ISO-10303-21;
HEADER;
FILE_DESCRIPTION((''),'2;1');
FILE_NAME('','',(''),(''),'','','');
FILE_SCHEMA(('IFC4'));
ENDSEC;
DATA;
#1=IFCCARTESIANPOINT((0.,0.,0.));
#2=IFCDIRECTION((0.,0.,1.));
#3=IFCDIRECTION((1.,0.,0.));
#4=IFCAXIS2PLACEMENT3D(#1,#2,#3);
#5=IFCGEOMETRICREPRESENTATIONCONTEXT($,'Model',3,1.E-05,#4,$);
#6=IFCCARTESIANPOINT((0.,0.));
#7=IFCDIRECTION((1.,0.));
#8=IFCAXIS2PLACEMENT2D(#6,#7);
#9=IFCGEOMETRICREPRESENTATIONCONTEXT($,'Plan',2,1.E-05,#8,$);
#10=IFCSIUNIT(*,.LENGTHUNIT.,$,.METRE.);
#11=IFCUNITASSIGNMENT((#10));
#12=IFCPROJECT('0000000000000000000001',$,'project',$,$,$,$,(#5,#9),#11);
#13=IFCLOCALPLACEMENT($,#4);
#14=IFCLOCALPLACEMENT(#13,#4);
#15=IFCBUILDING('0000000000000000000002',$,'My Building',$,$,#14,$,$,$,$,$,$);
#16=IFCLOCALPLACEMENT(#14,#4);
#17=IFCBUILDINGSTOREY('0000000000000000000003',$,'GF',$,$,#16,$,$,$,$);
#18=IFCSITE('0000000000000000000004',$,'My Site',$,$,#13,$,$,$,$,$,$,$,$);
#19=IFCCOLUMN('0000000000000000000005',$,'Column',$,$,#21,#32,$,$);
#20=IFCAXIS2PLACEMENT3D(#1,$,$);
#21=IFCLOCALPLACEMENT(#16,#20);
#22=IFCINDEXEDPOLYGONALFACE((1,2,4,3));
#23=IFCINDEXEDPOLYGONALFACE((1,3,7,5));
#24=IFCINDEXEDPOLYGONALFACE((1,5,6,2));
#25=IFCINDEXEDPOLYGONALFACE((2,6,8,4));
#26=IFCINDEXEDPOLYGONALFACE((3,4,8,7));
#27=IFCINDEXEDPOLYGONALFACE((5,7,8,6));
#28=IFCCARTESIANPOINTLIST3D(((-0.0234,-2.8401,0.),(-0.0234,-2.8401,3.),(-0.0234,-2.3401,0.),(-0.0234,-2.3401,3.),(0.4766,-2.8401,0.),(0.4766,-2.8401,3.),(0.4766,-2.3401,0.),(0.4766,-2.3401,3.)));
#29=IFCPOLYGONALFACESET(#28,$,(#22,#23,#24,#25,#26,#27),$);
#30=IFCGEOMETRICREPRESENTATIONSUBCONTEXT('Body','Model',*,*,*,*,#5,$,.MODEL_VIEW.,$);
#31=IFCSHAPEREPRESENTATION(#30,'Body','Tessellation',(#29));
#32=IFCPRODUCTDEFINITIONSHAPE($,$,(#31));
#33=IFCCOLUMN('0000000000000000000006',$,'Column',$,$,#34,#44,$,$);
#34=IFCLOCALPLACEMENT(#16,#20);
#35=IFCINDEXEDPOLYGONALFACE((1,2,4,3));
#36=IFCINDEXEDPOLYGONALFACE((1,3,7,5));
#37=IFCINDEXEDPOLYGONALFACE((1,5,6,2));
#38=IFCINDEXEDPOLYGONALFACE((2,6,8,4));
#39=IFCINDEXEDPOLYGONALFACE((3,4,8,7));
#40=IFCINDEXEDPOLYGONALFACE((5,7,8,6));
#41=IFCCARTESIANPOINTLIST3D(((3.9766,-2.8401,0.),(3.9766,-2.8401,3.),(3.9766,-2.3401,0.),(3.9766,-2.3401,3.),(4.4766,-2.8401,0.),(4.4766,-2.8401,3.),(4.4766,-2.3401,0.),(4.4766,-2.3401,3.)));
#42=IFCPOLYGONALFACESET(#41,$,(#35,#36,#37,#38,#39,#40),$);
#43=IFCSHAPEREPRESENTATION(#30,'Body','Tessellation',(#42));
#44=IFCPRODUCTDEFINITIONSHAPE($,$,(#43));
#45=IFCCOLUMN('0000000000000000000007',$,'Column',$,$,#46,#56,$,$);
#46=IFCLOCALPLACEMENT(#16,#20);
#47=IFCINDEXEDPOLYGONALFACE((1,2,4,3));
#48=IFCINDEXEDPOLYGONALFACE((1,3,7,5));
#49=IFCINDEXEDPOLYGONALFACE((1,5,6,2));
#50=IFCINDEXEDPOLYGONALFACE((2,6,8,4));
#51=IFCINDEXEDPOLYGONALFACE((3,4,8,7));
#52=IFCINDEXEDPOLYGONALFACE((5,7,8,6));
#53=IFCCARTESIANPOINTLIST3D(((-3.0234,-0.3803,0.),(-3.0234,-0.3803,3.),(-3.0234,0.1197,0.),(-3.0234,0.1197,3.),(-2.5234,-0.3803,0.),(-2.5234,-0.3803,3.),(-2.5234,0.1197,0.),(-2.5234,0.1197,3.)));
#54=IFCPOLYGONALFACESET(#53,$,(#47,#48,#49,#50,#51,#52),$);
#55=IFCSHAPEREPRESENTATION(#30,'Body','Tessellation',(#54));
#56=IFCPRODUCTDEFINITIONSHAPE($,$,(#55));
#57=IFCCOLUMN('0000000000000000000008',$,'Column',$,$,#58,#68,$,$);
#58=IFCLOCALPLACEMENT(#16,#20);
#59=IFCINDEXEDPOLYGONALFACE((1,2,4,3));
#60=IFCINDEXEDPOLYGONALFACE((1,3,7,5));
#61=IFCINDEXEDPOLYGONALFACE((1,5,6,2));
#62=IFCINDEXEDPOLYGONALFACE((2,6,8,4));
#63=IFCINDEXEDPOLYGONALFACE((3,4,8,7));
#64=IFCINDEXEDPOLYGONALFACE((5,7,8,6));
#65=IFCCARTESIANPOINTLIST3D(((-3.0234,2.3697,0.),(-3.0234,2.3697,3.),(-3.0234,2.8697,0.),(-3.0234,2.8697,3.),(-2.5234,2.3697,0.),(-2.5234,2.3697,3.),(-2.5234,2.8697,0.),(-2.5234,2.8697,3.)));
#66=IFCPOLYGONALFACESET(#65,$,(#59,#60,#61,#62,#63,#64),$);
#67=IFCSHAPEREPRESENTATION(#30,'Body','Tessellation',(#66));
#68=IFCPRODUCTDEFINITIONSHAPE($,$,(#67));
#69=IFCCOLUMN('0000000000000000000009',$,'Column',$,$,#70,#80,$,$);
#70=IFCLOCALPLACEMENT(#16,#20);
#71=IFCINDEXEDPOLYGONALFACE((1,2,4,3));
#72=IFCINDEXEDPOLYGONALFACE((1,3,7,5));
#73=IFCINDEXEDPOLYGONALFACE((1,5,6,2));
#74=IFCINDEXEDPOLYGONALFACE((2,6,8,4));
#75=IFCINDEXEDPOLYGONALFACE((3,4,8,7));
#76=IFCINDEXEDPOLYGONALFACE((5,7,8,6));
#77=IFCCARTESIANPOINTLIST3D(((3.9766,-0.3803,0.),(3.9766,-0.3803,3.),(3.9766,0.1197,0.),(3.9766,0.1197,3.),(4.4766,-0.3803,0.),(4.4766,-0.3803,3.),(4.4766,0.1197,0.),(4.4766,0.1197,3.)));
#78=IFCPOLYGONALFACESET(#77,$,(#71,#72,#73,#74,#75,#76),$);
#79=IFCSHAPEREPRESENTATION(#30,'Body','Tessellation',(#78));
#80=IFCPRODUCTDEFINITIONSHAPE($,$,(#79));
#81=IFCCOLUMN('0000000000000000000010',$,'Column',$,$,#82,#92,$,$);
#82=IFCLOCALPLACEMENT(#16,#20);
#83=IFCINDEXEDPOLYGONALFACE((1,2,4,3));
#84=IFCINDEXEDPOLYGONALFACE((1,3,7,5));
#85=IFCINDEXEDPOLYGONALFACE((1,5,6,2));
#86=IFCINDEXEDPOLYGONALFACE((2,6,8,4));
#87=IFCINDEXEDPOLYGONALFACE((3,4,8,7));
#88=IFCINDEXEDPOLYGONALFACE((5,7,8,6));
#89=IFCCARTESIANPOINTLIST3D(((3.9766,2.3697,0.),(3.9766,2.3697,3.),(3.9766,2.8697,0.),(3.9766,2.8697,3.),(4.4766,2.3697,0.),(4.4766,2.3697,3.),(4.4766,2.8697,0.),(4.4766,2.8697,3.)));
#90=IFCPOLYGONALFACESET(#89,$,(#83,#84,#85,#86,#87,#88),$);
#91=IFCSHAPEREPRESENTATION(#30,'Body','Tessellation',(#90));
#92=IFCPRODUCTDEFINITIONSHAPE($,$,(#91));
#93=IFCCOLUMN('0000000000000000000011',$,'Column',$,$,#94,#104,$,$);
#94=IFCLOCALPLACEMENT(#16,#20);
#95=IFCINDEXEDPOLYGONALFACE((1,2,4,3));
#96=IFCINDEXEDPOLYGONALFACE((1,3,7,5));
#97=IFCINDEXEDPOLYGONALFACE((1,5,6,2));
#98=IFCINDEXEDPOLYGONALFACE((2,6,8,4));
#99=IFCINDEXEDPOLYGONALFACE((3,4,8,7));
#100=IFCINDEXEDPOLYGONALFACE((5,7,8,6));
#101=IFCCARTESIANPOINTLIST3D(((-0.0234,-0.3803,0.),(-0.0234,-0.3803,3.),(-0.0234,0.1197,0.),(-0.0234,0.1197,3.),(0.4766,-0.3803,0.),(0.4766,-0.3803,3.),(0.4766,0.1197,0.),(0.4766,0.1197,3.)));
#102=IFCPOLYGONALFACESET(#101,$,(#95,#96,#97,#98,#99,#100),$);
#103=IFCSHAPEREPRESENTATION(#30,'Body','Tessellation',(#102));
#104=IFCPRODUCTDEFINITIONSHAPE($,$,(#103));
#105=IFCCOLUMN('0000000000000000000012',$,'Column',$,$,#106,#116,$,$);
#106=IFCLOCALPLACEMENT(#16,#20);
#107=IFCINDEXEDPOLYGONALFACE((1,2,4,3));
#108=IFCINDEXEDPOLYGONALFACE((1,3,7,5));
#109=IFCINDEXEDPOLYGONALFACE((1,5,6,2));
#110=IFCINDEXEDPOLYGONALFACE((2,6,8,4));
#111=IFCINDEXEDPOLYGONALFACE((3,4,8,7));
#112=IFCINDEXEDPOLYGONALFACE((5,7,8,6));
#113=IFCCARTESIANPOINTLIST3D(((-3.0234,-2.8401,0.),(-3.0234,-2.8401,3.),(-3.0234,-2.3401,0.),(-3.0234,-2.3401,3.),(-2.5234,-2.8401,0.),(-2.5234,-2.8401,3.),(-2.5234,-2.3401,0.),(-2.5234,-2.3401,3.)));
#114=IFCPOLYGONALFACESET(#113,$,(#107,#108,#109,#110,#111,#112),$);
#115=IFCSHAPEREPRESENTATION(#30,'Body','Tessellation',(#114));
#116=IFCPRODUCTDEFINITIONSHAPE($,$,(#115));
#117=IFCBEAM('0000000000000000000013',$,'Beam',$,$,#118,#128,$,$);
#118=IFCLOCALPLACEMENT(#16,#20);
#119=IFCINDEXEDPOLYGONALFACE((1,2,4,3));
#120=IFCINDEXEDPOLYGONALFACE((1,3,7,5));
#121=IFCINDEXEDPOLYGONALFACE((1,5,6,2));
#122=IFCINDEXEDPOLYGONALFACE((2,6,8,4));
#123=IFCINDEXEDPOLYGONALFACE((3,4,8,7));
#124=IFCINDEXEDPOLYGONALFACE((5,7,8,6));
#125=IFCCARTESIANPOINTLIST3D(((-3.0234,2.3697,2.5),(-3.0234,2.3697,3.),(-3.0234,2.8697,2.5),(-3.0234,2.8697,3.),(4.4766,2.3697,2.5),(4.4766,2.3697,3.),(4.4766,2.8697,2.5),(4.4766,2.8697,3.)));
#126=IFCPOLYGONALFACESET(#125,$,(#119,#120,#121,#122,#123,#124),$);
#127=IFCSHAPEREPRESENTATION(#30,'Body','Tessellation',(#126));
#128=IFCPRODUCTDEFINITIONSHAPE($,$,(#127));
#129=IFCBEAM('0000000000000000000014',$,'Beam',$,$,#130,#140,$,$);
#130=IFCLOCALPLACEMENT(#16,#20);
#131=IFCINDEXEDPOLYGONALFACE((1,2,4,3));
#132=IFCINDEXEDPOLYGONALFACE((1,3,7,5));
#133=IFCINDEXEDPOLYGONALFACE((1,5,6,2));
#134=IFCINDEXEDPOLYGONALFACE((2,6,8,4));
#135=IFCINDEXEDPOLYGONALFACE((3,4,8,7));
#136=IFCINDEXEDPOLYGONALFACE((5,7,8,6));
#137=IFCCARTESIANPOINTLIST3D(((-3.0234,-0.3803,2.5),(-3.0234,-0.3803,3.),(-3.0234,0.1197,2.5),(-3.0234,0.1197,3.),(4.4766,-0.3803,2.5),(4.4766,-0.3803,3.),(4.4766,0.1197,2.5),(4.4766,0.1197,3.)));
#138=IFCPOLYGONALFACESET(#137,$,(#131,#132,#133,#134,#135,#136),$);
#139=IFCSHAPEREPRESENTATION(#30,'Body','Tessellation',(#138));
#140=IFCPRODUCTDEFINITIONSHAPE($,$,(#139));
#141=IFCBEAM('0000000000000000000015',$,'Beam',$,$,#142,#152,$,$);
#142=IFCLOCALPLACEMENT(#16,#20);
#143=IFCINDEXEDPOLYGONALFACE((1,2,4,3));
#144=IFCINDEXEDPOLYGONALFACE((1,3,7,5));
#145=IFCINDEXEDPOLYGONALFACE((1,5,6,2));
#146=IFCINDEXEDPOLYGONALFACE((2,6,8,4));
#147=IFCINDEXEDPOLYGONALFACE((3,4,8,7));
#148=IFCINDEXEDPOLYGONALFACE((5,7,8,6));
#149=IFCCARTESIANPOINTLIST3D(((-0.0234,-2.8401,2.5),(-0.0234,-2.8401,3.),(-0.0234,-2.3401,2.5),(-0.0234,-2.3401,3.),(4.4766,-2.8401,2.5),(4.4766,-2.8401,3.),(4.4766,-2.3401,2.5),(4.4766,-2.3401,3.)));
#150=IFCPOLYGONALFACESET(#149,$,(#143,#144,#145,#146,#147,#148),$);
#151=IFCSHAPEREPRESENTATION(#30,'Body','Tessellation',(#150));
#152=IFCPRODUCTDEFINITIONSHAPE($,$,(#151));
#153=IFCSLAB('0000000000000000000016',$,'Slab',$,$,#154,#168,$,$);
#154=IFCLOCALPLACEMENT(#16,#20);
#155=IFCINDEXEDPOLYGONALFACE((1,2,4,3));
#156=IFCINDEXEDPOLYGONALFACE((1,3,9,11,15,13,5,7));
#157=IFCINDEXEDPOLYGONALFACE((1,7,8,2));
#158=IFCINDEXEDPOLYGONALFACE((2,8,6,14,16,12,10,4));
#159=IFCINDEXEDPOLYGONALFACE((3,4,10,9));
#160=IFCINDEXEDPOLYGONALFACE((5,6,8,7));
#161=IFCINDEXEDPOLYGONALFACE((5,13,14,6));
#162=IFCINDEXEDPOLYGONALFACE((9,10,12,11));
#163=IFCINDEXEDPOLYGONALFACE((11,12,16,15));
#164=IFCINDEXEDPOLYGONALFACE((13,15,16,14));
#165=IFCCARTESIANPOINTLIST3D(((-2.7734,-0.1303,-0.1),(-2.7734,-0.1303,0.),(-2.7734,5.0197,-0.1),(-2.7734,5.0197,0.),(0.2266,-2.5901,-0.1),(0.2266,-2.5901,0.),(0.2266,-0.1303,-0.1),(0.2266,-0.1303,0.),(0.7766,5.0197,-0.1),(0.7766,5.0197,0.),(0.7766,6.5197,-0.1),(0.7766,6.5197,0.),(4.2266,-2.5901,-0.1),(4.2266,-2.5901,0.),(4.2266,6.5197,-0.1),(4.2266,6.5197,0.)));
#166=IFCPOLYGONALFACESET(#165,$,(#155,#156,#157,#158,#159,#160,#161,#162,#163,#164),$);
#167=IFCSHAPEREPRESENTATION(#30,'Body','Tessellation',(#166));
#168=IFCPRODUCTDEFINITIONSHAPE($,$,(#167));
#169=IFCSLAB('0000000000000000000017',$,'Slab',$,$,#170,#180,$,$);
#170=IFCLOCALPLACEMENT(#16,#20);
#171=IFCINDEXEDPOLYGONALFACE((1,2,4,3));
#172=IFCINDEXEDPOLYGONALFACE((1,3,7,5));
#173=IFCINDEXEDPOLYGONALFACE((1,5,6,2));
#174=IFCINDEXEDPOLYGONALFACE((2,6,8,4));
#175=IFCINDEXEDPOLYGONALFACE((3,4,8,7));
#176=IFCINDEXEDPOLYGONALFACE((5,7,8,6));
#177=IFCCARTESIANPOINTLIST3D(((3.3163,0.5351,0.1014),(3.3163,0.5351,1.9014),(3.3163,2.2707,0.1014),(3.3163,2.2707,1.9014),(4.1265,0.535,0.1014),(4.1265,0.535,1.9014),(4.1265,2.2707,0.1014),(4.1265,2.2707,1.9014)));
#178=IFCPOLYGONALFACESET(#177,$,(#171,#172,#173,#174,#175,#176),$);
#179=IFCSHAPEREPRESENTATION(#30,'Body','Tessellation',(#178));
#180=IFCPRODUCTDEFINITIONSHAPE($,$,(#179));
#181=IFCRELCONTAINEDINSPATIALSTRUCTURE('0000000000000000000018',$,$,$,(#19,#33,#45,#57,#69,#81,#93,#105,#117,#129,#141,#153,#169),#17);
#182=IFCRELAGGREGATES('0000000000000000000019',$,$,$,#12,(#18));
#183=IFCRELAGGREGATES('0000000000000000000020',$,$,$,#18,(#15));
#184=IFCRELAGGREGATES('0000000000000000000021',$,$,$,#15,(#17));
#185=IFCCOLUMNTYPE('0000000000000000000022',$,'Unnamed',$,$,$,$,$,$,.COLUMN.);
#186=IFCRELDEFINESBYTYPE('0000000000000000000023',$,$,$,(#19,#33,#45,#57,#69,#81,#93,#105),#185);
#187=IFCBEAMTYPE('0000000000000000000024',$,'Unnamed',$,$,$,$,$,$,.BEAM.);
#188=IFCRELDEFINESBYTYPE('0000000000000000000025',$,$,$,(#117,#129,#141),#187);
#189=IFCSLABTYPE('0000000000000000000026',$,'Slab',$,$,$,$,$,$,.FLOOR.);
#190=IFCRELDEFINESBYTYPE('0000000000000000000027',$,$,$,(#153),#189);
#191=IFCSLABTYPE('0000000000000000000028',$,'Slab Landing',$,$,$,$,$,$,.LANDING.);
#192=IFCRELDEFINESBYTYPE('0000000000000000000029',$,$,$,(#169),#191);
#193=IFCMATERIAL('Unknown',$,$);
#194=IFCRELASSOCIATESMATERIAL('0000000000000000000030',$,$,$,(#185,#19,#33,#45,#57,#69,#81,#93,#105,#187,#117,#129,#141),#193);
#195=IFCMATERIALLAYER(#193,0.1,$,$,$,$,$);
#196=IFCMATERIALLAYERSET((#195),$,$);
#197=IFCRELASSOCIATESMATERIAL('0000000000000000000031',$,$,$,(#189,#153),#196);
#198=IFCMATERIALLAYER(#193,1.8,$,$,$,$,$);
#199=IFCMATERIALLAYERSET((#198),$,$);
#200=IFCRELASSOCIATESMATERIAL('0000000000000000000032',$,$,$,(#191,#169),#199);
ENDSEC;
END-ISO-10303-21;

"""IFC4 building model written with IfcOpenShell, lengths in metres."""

from ifc_helpers import new_model, si_unit, frame, origin_with_axes, origin_2d_with_axis, place, context, subcontext, project, spatial, indexed_curve, rectangle, outline, extrude, material, layer, layer_set, layer_usage, material_profile, profile_set, profile_usage, type_object, element, save


model = new_model("IFC4")

# Units and contexts
model_context = context("Model", 3, precision=1e-05, world=origin_with_axes())
plan_context = context("Plan", 2, precision=1e-05, world=origin_2d_with_axis())
body_context_1 = subcontext(model_context, "Body", "Model", "MODEL_VIEW")
ifc_project = project(units=[si_unit("LENGTHUNIT", "METRE")], contexts=[model_context, plan_context])

# Site, building, storey
site_placement = place(None, origin_with_axes())
site = spatial("IfcSite", under=ifc_project, at=site_placement, Name="My Site")
building_placement = place(site_placement, origin_with_axes())
building = spatial("IfcBuilding", under=site, at=building_placement, Name="My Building")
storey_placement = place(building_placement, origin_with_axes())
storey = spatial("IfcBuildingStorey", under=building, at=storey_placement, Name="GF")

# Columns
ifc_material = material(Name="Unknown")
ifc_material_profile_1 = material_profile(ifc_material, rectangle(XDim=0.5, YDim=0.5))
ifc_profile_set_1 = profile_set([ifc_material_profile_1])
ifc_profile_usage_1 = profile_usage(ifc_profile_set_1, cardinal=5)
column_type = type_object("IfcColumnType", Name="Unnamed", PredefinedType="COLUMN", material=ifc_profile_set_1)
column_1_placement = place(storey_placement, frame((0.2266, -2.5901, 0.0), z_axis=(0.0, 0.0, 1.0), x_axis=(1.0, 0.0, 0.0)))
element("IfcColumn", 1, at=column_1_placement, inside=storey, type_object=column_type, material=ifc_profile_usage_1, Name="Column", context=body_context_1, shape_type="SweptSolid", body=[
    extrude(rectangle(XDim=0.5, YDim=0.5), origin_with_axes(), (0.0, 0.0, 1.0), 3.0),
])
ifc_profile_usage_2 = profile_usage(ifc_profile_set_1, cardinal=5)
column_2_placement = place(storey_placement, frame((4.2266, -2.5901, 0.0), z_axis=(0.0, 0.0, 1.0), x_axis=(1.0, 0.0, 0.0)))
element("IfcColumn", 2, at=column_2_placement, inside=storey, type_object=column_type, material=ifc_profile_usage_2, Name="Column", context=body_context_1, shape_type="SweptSolid", body=[
    extrude(rectangle(XDim=0.5, YDim=0.5), origin_with_axes(), (0.0, 0.0, 1.0), 3.0),
])
ifc_profile_usage_3 = profile_usage(ifc_profile_set_1, cardinal=5)
column_3_placement = place(storey_placement, frame((-2.7734, -0.1303, 0.0), z_axis=(0.0, 0.0, 1.0), x_axis=(1.0, 0.0, 0.0)))
element("IfcColumn", 3, at=column_3_placement, inside=storey, type_object=column_type, material=ifc_profile_usage_3, Name="Column", context=body_context_1, shape_type="SweptSolid", body=[
    extrude(rectangle(XDim=0.5, YDim=0.5), origin_with_axes(), (0.0, 0.0, 1.0), 3.0),
])
ifc_profile_usage_4 = profile_usage(ifc_profile_set_1, cardinal=5)
column_4_placement = place(storey_placement, frame((-2.7734, 2.6197, 0.0), z_axis=(0.0, 0.0, 1.0), x_axis=(1.0, 0.0, 0.0)))
element("IfcColumn", 4, at=column_4_placement, inside=storey, type_object=column_type, material=ifc_profile_usage_4, Name="Column", context=body_context_1, shape_type="SweptSolid", body=[
    extrude(rectangle(XDim=0.5, YDim=0.5), origin_with_axes(), (0.0, 0.0, 1.0), 3.0),
])
ifc_profile_usage_5 = profile_usage(ifc_profile_set_1, cardinal=5)
column_5_placement = place(storey_placement, frame((4.2266, -0.1303, 0.0), z_axis=(0.0, 0.0, 1.0), x_axis=(1.0, 0.0, 0.0)))
element("IfcColumn", 5, at=column_5_placement, inside=storey, type_object=column_type, material=ifc_profile_usage_5, Name="Column", context=body_context_1, shape_type="SweptSolid", body=[
    extrude(rectangle(XDim=0.5, YDim=0.5), origin_with_axes(), (0.0, 0.0, 1.0), 3.0),
])
ifc_profile_usage_6 = profile_usage(ifc_profile_set_1, cardinal=5)
column_6_placement = place(storey_placement, frame((4.2266, 2.6197, 0.0), z_axis=(0.0, 0.0, 1.0), x_axis=(1.0, 0.0, 0.0)))
element("IfcColumn", 6, at=column_6_placement, inside=storey, type_object=column_type, material=ifc_profile_usage_6, Name="Column", context=body_context_1, shape_type="SweptSolid", body=[
    extrude(rectangle(XDim=0.5, YDim=0.5), origin_with_axes(), (0.0, 0.0, 1.0), 3.0),
])
ifc_profile_usage_7 = profile_usage(ifc_profile_set_1, cardinal=5)
column_7_placement = place(storey_placement, frame((0.2266, -0.1303, 0.0), z_axis=(0.0, 0.0, 1.0), x_axis=(1.0, 0.0, 0.0)))
element("IfcColumn", 7, at=column_7_placement, inside=storey, type_object=column_type, material=ifc_profile_usage_7, Name="Column", context=body_context_1, shape_type="SweptSolid", body=[
    extrude(rectangle(XDim=0.5, YDim=0.5), origin_with_axes(), (0.0, 0.0, 1.0), 3.0),
])
ifc_profile_usage_8 = profile_usage(ifc_profile_set_1, cardinal=5)
column_8_placement = place(storey_placement, frame((-2.7734, -2.5901, 0.0), z_axis=(0.0, 0.0, 1.0), x_axis=(1.0, 0.0, 0.0)))
element("IfcColumn", 8, at=column_8_placement, inside=storey, type_object=column_type, material=ifc_profile_usage_8, Name="Column", context=body_context_1, shape_type="SweptSolid", body=[
    extrude(rectangle(XDim=0.5, YDim=0.5), origin_with_axes(), (0.0, 0.0, 1.0), 3.0),
])

# Beams
ifc_material_profile_2 = material_profile(ifc_material, rectangle(XDim=0.5, YDim=0.5))
ifc_profile_set_2 = profile_set([ifc_material_profile_2])
ifc_profile_usage_9 = profile_usage(ifc_profile_set_2, cardinal=7)
beam_type = type_object("IfcBeamType", Name="Unnamed", PredefinedType="BEAM", material=ifc_profile_set_2)
beam_1_placement = place(storey_placement, frame((4.4766, 2.3697, 3.0), z_axis=(-1.0, 0.0, 0.0), x_axis=(0.0, -1.0, 0.0)))
element("IfcBeam", 9, at=beam_1_placement, inside=storey, type_object=beam_type, material=ifc_profile_usage_9, Name="Beam", context=body_context_1, shape_type="SweptSolid", body=[
    extrude(rectangle(XDim=0.5, YDim=0.5), frame((-0.25, -0.25, 0.0), z_axis=(0.0, 0.0, 1.0), x_axis=(1.0, 0.0, 0.0)), (0.0, 0.0, 1.0), 7.5),
])
ifc_profile_usage_10 = profile_usage(ifc_profile_set_2, cardinal=7)
beam_2_placement = place(storey_placement, frame((4.4766, -0.3803, 3.0), z_axis=(-1.0, 0.0, 0.0), x_axis=(0.0, -1.0, 0.0)))
element("IfcBeam", 10, at=beam_2_placement, inside=storey, type_object=beam_type, material=ifc_profile_usage_10, Name="Beam", context=body_context_1, shape_type="SweptSolid", body=[
    extrude(rectangle(XDim=0.5, YDim=0.5), frame((-0.25, -0.25, 0.0), z_axis=(0.0, 0.0, 1.0), x_axis=(1.0, 0.0, 0.0)), (0.0, 0.0, 1.0), 7.5),
])
ifc_profile_usage_11 = profile_usage(ifc_profile_set_2, cardinal=7)
beam_3_placement = place(storey_placement, frame((4.4766, -2.8401, 3.0), z_axis=(-1.0, -0.000001, 0.000001), x_axis=(0.000001, -1.0, 0.0)))
element("IfcBeam", 11, at=beam_3_placement, inside=storey, type_object=beam_type, material=ifc_profile_usage_11, Name="Beam", context=body_context_1, shape_type="SweptSolid", body=[
    extrude(rectangle(XDim=0.5, YDim=0.5), frame((-0.25, -0.25, 0.0), z_axis=(0.0, 0.0, 1.0), x_axis=(1.0, 0.0, 0.0)), (0.0, 0.0, 1.0), 4.5),
])

# Slabs
ifc_layer_1 = layer(ifc_material, 0.1)
ifc_layer_set_1 = layer_set([ifc_layer_1])
ifc_layer_usage_1 = layer_usage(ifc_layer_set_1, "AXIS3", "POSITIVE", -0.1)
slab_type_1 = type_object("IfcSlabType", Name="Slab", PredefinedType="FLOOR", material=ifc_layer_set_1)
slab_1_placement = place(storey_placement, frame((4.2266, -2.5901, 0.0), z_axis=(0.0, 0.0, 1.0), x_axis=(1.0, 0.0, 0.0)))
element("IfcSlab", 12, at=slab_1_placement, inside=storey, type_object=slab_type_1, material=ifc_layer_usage_1, Name="Slab", context=body_context_1, shape_type="SweptSolid", body=[
    extrude(outline(indexed_curve([(0.0, 0.0), (0.0, 9.1098), (-3.45, 9.1098), (-3.45, 7.6098), (-7.0, 7.6098), (-7.0, 2.4598), (-4.0, 2.4598), (-4.0, 0.0), (0.0, 0.0)])), frame((0.0, 0.0, -0.1), z_axis=(0.0, 0.0, 1.0), x_axis=(1.0, 0.0, 0.0)), (0.0, 0.0, 1.0), 0.1),
])
ifc_layer_2 = layer(ifc_material, 1.8)
ifc_layer_set_2 = layer_set([ifc_layer_2])
ifc_layer_usage_2 = layer_usage(ifc_layer_set_2, "AXIS3", "POSITIVE", -1.8)
slab_type_2 = type_object("IfcSlabType", Name="Slab Landing", PredefinedType="LANDING", material=ifc_layer_set_2)
slab_2_placement = place(storey_placement, frame((3.3163, 0.5351, 1.9014), z_axis=(0.0, 0.0, 1.0), x_axis=(1.0, 0.0, 0.0)))
element("IfcSlab", 13, at=slab_2_placement, inside=storey, type_object=slab_type_2, material=ifc_layer_usage_2, Name="Slab", context=body_context_1, shape_type="SweptSolid", body=[
    extrude(outline(indexed_curve([(0.0, 0.0), (0.0, 1.7356), (0.8103, 1.7356), (0.8103, -0.0001), (0.0, 0.0)])), frame((0.0, 0.0, -1.8), z_axis=(0.0, 0.0, 1.0), x_axis=(1.0, 0.0, 0.0)), (0.0, 0.0, 1.0), 1.8),
])

save(model, "model.ifc")
